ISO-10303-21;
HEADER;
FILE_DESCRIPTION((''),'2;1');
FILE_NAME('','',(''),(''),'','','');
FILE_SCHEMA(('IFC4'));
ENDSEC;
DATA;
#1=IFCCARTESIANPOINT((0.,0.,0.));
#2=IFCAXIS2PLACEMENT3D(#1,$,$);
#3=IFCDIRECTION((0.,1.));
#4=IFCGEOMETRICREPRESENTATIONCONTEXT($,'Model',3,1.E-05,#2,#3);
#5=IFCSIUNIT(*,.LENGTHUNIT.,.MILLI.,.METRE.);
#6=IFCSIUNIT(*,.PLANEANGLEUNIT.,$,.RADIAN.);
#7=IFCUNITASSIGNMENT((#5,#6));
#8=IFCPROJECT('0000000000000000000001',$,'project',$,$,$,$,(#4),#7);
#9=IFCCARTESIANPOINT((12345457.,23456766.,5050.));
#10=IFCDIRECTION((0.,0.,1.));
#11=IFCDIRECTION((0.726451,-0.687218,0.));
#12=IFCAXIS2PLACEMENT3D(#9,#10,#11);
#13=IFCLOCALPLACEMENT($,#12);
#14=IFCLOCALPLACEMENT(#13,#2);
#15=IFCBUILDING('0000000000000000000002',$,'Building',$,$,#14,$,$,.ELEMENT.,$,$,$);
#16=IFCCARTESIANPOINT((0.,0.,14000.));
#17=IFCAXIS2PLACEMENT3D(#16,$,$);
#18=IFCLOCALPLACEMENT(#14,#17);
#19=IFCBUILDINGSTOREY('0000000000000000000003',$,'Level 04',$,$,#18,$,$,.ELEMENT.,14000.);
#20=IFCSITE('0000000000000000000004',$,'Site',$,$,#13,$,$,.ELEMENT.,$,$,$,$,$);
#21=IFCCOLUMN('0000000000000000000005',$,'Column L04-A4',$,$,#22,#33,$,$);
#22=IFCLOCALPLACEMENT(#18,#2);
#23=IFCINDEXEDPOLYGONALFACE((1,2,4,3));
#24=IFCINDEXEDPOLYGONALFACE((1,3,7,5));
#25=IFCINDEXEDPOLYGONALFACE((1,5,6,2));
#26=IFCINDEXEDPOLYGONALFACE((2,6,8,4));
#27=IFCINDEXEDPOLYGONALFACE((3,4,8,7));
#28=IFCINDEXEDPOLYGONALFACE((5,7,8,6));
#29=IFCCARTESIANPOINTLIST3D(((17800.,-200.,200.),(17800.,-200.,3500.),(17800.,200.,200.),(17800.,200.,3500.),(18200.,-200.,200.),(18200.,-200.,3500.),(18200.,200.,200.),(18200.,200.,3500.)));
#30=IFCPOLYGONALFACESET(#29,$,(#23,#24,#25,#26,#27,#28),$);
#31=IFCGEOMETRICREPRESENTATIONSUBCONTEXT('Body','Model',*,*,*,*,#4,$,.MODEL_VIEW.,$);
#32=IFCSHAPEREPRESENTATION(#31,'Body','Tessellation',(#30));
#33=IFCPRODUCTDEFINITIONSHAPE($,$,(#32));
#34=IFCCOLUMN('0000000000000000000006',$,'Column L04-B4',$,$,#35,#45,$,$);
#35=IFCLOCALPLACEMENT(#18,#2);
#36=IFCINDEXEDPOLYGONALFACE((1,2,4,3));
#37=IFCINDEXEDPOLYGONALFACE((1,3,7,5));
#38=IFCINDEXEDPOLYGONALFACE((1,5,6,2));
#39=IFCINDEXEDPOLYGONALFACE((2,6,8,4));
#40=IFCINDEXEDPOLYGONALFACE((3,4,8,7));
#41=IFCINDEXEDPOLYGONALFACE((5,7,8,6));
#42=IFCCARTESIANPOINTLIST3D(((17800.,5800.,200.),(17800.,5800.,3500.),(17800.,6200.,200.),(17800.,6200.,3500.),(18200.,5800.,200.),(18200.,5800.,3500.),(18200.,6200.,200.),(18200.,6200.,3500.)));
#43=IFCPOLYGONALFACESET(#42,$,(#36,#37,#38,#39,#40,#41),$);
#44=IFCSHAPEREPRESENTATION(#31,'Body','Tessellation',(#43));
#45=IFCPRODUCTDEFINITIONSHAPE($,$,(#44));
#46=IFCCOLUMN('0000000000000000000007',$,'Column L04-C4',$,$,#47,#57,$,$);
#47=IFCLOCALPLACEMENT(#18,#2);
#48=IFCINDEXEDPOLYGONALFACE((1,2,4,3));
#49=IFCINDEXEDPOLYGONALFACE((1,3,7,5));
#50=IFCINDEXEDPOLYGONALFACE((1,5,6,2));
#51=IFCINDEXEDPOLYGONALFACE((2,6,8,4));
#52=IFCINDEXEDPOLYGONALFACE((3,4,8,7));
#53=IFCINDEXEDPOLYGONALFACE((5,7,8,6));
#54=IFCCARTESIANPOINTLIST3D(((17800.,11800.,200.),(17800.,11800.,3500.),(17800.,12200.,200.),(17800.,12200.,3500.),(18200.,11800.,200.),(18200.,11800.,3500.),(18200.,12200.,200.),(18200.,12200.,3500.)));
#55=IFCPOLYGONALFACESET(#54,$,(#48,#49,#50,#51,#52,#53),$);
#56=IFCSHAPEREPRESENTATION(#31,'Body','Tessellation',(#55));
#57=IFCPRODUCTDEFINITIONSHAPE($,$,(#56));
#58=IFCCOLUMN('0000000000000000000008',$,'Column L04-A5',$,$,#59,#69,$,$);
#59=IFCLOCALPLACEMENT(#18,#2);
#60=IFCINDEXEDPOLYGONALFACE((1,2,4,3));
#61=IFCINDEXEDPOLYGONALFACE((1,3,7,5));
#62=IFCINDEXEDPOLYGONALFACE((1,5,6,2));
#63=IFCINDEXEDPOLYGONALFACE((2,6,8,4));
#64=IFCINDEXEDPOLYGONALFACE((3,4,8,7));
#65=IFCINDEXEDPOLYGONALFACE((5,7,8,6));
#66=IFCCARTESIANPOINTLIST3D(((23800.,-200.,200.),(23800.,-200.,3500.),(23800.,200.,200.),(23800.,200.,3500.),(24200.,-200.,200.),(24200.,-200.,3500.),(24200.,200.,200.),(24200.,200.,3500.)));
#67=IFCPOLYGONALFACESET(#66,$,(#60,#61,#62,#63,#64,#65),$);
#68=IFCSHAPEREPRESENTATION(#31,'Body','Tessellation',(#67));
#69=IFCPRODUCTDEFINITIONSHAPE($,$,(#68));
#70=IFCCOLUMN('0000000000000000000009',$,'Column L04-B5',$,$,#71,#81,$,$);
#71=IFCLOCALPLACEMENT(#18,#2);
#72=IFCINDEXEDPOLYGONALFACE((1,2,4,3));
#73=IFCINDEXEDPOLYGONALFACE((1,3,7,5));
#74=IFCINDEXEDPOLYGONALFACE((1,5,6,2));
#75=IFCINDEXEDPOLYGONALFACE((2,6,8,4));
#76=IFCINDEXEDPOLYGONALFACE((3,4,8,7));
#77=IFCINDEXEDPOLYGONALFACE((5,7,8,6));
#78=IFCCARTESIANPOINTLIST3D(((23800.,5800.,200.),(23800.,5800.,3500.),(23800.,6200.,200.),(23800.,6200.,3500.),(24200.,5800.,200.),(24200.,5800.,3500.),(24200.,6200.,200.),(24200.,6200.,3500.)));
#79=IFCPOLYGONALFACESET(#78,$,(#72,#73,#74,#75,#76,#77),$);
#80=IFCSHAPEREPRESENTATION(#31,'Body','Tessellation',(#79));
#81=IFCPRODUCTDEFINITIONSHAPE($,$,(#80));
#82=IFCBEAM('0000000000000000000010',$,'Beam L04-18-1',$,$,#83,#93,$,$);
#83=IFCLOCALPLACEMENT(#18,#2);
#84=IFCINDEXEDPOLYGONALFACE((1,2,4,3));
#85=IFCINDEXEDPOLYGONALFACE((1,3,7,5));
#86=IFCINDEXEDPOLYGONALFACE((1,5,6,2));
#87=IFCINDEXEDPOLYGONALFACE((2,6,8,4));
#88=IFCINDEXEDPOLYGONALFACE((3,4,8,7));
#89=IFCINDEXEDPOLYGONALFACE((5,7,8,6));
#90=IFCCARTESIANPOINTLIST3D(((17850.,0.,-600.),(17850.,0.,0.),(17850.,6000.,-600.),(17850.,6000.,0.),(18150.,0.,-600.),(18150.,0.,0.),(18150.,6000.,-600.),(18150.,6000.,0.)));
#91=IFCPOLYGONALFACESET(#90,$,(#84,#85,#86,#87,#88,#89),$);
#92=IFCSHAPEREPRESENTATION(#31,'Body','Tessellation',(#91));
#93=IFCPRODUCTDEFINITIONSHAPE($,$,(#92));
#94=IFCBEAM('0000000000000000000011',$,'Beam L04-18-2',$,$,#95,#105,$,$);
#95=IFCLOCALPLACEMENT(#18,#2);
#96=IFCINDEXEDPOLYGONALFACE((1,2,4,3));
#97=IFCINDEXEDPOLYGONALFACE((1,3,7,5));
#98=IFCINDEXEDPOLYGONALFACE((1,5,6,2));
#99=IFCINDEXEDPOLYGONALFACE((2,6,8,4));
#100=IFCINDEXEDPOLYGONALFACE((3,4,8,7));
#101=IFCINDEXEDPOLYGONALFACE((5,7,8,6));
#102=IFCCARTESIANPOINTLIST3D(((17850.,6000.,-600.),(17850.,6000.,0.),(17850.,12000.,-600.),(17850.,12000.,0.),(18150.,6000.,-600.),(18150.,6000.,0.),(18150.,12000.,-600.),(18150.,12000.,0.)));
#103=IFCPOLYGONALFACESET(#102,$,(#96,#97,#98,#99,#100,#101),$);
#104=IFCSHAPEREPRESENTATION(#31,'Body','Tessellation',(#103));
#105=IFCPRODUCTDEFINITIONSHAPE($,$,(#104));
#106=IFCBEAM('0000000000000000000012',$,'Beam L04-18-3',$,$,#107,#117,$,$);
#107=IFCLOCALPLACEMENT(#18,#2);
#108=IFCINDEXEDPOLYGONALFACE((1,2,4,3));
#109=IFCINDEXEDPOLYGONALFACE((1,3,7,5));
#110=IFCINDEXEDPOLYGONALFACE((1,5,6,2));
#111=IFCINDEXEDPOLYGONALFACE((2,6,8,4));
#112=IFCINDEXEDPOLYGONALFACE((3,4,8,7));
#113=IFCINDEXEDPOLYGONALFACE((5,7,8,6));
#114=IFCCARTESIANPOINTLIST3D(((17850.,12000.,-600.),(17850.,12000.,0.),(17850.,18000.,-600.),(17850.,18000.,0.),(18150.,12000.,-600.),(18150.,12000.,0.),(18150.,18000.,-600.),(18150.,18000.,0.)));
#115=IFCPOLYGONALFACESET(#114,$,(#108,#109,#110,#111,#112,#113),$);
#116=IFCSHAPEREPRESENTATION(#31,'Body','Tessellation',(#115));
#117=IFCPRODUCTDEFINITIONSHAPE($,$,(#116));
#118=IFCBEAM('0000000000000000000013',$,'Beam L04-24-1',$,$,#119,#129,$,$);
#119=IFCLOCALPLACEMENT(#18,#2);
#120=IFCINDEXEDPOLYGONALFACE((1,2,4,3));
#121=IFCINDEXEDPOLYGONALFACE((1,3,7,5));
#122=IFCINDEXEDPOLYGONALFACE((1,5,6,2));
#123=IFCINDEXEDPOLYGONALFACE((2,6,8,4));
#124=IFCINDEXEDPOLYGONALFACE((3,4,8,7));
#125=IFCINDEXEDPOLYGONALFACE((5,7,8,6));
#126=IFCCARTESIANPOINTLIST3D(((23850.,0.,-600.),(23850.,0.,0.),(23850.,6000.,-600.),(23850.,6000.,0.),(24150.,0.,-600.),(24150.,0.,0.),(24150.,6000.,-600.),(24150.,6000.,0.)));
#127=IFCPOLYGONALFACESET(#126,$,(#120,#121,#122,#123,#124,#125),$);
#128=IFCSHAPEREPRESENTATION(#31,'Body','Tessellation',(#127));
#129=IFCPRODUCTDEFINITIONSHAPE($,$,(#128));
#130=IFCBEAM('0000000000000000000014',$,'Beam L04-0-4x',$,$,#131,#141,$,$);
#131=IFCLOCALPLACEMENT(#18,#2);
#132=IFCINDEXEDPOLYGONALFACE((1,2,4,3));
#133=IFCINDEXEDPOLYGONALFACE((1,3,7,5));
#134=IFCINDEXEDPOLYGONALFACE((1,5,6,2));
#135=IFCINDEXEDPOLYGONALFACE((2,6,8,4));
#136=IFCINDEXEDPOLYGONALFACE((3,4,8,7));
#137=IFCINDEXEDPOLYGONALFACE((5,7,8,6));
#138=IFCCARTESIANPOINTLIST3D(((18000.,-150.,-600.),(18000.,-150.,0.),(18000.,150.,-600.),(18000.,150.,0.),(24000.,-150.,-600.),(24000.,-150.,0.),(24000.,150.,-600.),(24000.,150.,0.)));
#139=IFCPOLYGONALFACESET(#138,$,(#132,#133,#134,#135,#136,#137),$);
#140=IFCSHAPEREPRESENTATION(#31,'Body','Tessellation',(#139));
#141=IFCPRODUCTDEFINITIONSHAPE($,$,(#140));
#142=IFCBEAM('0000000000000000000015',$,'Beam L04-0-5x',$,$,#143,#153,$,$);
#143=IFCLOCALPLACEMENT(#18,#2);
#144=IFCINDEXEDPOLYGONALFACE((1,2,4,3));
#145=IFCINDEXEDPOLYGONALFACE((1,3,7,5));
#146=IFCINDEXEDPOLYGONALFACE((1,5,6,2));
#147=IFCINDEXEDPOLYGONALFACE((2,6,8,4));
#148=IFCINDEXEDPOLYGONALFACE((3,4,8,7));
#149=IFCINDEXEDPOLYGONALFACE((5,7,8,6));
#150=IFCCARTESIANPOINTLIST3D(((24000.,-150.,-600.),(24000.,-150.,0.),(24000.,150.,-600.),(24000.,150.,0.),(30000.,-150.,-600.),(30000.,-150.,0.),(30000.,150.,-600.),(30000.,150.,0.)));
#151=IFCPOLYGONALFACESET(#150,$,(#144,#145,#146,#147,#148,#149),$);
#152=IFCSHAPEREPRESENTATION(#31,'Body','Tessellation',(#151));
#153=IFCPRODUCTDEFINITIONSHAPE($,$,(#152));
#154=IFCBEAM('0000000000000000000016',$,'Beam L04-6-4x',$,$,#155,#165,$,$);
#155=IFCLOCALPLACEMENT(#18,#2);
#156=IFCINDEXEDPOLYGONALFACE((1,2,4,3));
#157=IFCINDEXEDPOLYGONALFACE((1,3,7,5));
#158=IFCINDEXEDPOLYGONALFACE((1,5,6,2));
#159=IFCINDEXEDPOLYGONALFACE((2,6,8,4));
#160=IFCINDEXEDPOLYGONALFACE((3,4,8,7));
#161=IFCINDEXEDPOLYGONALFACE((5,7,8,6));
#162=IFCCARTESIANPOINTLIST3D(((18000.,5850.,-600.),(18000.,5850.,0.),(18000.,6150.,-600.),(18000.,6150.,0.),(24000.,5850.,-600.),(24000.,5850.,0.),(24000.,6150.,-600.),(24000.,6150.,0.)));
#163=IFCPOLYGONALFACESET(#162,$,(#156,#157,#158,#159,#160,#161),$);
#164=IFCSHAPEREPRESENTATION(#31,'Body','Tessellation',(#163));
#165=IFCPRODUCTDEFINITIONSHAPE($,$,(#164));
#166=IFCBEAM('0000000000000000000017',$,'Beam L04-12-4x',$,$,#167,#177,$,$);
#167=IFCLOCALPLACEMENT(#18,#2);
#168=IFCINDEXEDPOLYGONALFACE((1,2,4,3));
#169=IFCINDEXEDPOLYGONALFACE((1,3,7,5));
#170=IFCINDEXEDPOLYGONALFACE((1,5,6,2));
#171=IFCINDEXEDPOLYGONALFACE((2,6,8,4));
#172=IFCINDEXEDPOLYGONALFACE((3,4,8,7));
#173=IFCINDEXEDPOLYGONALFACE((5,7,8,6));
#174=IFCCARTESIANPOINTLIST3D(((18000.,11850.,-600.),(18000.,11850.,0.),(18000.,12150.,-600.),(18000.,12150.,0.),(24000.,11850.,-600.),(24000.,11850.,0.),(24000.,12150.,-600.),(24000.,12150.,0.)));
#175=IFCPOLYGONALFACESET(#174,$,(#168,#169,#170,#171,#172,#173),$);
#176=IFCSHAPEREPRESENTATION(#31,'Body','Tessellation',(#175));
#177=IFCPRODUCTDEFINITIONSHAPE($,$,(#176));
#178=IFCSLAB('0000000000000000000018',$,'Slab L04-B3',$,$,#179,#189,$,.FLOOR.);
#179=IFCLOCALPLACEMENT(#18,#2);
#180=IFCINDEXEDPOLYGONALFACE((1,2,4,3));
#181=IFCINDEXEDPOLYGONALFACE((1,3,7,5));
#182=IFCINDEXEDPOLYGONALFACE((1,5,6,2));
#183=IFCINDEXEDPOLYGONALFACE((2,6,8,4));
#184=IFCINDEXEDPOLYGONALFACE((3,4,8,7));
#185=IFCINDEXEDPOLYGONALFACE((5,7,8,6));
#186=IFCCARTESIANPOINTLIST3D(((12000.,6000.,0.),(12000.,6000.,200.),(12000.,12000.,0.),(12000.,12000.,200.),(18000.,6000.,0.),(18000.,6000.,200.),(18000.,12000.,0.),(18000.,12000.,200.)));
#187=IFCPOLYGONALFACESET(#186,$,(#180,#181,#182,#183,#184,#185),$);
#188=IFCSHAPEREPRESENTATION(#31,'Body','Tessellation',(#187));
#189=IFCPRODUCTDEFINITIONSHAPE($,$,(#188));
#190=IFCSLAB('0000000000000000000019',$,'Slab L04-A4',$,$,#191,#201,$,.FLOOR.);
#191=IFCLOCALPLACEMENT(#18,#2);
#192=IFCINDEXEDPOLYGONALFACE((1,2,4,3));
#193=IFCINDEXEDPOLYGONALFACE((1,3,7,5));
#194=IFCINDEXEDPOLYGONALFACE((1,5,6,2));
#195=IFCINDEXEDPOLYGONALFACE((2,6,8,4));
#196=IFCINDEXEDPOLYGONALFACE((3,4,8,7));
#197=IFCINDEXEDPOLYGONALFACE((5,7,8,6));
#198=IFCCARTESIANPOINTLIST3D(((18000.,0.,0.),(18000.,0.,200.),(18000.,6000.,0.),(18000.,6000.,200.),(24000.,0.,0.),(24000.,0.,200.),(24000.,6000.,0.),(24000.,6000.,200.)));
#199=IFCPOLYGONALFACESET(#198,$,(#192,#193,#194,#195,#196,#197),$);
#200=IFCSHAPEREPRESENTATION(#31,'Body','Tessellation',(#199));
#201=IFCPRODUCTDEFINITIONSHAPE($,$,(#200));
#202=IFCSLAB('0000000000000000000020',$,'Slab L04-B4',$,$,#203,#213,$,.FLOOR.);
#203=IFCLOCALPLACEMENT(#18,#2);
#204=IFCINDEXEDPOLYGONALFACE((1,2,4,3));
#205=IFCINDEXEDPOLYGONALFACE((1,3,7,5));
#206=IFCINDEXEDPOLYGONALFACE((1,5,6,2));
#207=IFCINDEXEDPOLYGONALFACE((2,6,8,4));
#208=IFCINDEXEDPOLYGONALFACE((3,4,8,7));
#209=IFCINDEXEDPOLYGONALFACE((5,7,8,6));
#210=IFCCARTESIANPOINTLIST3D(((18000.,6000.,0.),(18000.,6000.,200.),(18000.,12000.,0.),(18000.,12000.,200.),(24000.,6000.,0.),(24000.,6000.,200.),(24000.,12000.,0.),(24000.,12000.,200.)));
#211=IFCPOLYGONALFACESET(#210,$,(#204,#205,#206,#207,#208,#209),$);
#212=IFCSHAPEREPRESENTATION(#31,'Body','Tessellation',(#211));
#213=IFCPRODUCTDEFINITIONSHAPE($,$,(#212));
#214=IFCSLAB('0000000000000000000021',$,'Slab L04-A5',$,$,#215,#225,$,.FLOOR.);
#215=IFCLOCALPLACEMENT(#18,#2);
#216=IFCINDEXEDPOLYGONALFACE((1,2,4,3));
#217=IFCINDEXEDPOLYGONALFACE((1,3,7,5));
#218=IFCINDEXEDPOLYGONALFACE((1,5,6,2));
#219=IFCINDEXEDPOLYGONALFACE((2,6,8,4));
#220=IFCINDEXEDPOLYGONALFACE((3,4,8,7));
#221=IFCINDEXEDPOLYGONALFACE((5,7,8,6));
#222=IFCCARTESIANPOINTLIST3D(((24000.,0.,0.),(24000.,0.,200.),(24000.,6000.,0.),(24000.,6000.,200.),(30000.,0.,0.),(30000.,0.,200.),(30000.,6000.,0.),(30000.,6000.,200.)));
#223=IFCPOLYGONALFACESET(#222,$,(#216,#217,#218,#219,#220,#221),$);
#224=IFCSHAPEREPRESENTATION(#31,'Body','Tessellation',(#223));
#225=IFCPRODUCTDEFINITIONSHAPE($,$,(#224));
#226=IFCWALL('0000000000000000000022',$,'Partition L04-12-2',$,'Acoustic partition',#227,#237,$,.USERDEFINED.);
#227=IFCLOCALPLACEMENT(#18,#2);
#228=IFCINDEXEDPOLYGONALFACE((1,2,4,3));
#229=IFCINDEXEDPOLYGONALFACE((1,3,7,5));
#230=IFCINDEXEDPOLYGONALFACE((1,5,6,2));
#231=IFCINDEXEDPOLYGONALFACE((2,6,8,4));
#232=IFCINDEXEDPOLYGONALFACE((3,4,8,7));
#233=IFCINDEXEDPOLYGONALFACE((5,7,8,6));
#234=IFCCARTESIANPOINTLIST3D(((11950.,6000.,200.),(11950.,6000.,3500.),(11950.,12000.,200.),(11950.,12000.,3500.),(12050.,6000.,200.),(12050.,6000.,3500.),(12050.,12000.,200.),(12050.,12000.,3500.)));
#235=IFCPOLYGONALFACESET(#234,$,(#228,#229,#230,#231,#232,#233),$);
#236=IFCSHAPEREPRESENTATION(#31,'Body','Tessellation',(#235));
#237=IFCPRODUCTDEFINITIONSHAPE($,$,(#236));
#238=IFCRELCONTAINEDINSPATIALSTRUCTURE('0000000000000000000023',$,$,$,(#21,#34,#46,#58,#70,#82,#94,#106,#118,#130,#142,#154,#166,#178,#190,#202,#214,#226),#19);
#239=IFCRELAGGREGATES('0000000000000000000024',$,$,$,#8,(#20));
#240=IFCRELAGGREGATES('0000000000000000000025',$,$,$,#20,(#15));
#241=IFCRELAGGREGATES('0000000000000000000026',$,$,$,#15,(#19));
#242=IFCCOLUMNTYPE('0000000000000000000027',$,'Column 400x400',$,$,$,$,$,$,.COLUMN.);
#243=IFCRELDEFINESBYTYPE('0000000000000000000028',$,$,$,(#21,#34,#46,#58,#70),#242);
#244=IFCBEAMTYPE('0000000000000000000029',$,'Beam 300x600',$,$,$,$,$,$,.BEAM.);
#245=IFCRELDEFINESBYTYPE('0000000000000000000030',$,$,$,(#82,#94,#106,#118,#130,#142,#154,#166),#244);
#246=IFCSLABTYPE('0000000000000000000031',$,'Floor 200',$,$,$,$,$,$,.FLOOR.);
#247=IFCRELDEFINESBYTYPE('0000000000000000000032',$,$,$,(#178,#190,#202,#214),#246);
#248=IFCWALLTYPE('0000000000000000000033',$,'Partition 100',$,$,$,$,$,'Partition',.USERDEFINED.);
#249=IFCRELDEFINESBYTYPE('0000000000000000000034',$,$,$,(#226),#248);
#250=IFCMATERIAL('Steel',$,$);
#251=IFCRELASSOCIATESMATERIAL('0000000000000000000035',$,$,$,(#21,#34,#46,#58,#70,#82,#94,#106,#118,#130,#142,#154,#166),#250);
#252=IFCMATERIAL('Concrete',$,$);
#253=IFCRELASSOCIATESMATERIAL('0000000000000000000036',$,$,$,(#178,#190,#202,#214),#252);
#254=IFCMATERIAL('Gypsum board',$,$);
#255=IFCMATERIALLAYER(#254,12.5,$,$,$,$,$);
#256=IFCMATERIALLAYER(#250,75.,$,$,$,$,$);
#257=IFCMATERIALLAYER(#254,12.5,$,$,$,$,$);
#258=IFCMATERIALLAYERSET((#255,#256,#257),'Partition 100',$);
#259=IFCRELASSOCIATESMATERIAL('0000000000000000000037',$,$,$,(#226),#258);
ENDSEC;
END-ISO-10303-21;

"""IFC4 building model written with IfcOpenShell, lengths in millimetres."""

from ifc_helpers import new_model, si_unit, direction, frame, origin, place, context, subcontext, project, spatial, rectangle, extrude, material, layer, layer_set, layer_usage, type_object, element, save


model = new_model("IFC4")

# Units and contexts
model_context = context("Model", 3, precision=1e-05, world=origin(), true_north=direction((0.0, 1.0)))
body_context = subcontext(model_context, "Body", "Model", "MODEL_VIEW")
ifc_project = project(units=[si_unit("LENGTHUNIT", "METRE", prefix="MILLI"), si_unit("PLANEANGLEUNIT", "RADIAN")], contexts=[model_context])

# Site, building, storey
site_placement = place(None, frame((12345457.0, 23456766.0, 5050.0), z_axis=(0.0, 0.0, 1.0), x_axis=(0.726451, -0.687218, 0.0)))
site = spatial("IfcSite", under=ifc_project, at=site_placement, Name="Site", CompositionType="ELEMENT")
building_placement = place(site_placement, origin())
building = spatial("IfcBuilding", under=site, at=building_placement, Name="Building", CompositionType="ELEMENT")
storey_placement = place(building_placement, frame((0.0, 0.0, 14000.0)))
storey = spatial("IfcBuildingStorey", under=building, at=storey_placement, Name="Level 04", CompositionType="ELEMENT", Elevation=14000.0)

# Columns
ifc_material_1 = material(Name="Steel")
column_type = type_object("IfcColumnType", Name="Column 400x400", PredefinedType="COLUMN")
for number, where, name in (
    (1, (17800.0, -200.0, 200.0), "Column L04-A4"),
    (2, (17800.0, 5800.0, 200.0), "Column L04-B4"),
    (3, (17800.0, 11800.0, 200.0), "Column L04-C4"),
    (4, (23800.0, -200.0, 200.0), "Column L04-A5"),
    (5, (23800.0, 5800.0, 200.0), "Column L04-B5"),
):
    element("IfcColumn", number, at=place(storey_placement, frame(where)), inside=storey, type_object=column_type, material=ifc_material_1, Name=name, context=body_context, shape_type="SweptSolid", body=[
        extrude(rectangle(XDim=400.0, YDim=400.0), frame((200.0, 200.0, 0.0)), (0.0, 0.0, 1.0), 3300.0),
    ])

# Beams
beam_type = type_object("IfcBeamType", Name="Beam 300x600", PredefinedType="BEAM")
for number, where, name in (
    (6, (17850.0, 0.0, -600.0), "Beam L04-18-1"),
    (7, (17850.0, 6000.0, -600.0), "Beam L04-18-2"),
    (8, (17850.0, 12000.0, -600.0), "Beam L04-18-3"),
    (9, (23850.0, 0.0, -600.0), "Beam L04-24-1"),
):
    element("IfcBeam", number, at=place(storey_placement, frame(where)), inside=storey, type_object=beam_type, material=ifc_material_1, Name=name, context=body_context, shape_type="SweptSolid", body=[
        extrude(rectangle(XDim=300.0, YDim=6000.0), frame((150.0, 3000.0, 0.0)), (0.0, 0.0, 1.0), 600.0),
    ])
for number, where, name in (
    (10, (18000.0, -150.0, -600.0), "Beam L04-0-4x"),
    (11, (24000.0, -150.0, -600.0), "Beam L04-0-5x"),
    (12, (18000.0, 5850.0, -600.0), "Beam L04-6-4x"),
    (13, (18000.0, 11850.0, -600.0), "Beam L04-12-4x"),
):
    element("IfcBeam", number, at=place(storey_placement, frame(where)), inside=storey, type_object=beam_type, material=ifc_material_1, Name=name, context=body_context, shape_type="SweptSolid", body=[
        extrude(rectangle(XDim=6000.0, YDim=300.0), frame((3000.0, 150.0, 0.0)), (0.0, 0.0, 1.0), 600.0),
    ])

# Slabs
ifc_material_2 = material(Name="Concrete")
slab_type = type_object("IfcSlabType", Name="Floor 200", PredefinedType="FLOOR")
for number, where, name in (
    (14, (12000.0, 6000.0, 0.0), "Slab L04-B3"),
    (15, (18000.0, 0.0, 0.0), "Slab L04-A4"),
    (16, (18000.0, 6000.0, 0.0), "Slab L04-B4"),
    (17, (24000.0, 0.0, 0.0), "Slab L04-A5"),
):
    element("IfcSlab", number, at=place(storey_placement, frame(where)), inside=storey, type_object=slab_type, material=ifc_material_2, Name=name, PredefinedType="FLOOR", context=body_context, shape_type="SweptSolid", body=[
        extrude(rectangle(XDim=6000.0, YDim=6000.0), frame((3000.0, 3000.0, 0.0)), (0.0, 0.0, 1.0), 200.0),
    ])

# Wall
ifc_material_3 = material(Name="Gypsum board")
ifc_layer_1 = layer(ifc_material_3, 12.5)
ifc_layer_2 = layer(ifc_material_1, 75.0)
ifc_layer_3 = layer(ifc_material_3, 12.5)
ifc_layer_set = layer_set([ifc_layer_1, ifc_layer_2, ifc_layer_3], Name="Partition 100")
ifc_layer_usage = layer_usage(ifc_layer_set, "AXIS2", "POSITIVE", 0.0)
wall_type = type_object("IfcWallType", Name="Partition 100", ElementType="Partition", PredefinedType="USERDEFINED")
for number, where, name in (
    (18, (11950.0, 6000.0, 200.0), "Partition L04-12-2"),
):
    element("IfcWall", number, at=place(storey_placement, frame(where)), inside=storey, type_object=wall_type, material=ifc_layer_usage, Name=name, ObjectType="Acoustic partition", PredefinedType="USERDEFINED", context=body_context, shape_type="SweptSolid", body=[
        extrude(rectangle(XDim=100.0, YDim=6000.0), frame((50.0, 3000.0, 0.0)), (0.0, 0.0, 1.0), 3300.0),
    ])

save(model, "model.ifc")
